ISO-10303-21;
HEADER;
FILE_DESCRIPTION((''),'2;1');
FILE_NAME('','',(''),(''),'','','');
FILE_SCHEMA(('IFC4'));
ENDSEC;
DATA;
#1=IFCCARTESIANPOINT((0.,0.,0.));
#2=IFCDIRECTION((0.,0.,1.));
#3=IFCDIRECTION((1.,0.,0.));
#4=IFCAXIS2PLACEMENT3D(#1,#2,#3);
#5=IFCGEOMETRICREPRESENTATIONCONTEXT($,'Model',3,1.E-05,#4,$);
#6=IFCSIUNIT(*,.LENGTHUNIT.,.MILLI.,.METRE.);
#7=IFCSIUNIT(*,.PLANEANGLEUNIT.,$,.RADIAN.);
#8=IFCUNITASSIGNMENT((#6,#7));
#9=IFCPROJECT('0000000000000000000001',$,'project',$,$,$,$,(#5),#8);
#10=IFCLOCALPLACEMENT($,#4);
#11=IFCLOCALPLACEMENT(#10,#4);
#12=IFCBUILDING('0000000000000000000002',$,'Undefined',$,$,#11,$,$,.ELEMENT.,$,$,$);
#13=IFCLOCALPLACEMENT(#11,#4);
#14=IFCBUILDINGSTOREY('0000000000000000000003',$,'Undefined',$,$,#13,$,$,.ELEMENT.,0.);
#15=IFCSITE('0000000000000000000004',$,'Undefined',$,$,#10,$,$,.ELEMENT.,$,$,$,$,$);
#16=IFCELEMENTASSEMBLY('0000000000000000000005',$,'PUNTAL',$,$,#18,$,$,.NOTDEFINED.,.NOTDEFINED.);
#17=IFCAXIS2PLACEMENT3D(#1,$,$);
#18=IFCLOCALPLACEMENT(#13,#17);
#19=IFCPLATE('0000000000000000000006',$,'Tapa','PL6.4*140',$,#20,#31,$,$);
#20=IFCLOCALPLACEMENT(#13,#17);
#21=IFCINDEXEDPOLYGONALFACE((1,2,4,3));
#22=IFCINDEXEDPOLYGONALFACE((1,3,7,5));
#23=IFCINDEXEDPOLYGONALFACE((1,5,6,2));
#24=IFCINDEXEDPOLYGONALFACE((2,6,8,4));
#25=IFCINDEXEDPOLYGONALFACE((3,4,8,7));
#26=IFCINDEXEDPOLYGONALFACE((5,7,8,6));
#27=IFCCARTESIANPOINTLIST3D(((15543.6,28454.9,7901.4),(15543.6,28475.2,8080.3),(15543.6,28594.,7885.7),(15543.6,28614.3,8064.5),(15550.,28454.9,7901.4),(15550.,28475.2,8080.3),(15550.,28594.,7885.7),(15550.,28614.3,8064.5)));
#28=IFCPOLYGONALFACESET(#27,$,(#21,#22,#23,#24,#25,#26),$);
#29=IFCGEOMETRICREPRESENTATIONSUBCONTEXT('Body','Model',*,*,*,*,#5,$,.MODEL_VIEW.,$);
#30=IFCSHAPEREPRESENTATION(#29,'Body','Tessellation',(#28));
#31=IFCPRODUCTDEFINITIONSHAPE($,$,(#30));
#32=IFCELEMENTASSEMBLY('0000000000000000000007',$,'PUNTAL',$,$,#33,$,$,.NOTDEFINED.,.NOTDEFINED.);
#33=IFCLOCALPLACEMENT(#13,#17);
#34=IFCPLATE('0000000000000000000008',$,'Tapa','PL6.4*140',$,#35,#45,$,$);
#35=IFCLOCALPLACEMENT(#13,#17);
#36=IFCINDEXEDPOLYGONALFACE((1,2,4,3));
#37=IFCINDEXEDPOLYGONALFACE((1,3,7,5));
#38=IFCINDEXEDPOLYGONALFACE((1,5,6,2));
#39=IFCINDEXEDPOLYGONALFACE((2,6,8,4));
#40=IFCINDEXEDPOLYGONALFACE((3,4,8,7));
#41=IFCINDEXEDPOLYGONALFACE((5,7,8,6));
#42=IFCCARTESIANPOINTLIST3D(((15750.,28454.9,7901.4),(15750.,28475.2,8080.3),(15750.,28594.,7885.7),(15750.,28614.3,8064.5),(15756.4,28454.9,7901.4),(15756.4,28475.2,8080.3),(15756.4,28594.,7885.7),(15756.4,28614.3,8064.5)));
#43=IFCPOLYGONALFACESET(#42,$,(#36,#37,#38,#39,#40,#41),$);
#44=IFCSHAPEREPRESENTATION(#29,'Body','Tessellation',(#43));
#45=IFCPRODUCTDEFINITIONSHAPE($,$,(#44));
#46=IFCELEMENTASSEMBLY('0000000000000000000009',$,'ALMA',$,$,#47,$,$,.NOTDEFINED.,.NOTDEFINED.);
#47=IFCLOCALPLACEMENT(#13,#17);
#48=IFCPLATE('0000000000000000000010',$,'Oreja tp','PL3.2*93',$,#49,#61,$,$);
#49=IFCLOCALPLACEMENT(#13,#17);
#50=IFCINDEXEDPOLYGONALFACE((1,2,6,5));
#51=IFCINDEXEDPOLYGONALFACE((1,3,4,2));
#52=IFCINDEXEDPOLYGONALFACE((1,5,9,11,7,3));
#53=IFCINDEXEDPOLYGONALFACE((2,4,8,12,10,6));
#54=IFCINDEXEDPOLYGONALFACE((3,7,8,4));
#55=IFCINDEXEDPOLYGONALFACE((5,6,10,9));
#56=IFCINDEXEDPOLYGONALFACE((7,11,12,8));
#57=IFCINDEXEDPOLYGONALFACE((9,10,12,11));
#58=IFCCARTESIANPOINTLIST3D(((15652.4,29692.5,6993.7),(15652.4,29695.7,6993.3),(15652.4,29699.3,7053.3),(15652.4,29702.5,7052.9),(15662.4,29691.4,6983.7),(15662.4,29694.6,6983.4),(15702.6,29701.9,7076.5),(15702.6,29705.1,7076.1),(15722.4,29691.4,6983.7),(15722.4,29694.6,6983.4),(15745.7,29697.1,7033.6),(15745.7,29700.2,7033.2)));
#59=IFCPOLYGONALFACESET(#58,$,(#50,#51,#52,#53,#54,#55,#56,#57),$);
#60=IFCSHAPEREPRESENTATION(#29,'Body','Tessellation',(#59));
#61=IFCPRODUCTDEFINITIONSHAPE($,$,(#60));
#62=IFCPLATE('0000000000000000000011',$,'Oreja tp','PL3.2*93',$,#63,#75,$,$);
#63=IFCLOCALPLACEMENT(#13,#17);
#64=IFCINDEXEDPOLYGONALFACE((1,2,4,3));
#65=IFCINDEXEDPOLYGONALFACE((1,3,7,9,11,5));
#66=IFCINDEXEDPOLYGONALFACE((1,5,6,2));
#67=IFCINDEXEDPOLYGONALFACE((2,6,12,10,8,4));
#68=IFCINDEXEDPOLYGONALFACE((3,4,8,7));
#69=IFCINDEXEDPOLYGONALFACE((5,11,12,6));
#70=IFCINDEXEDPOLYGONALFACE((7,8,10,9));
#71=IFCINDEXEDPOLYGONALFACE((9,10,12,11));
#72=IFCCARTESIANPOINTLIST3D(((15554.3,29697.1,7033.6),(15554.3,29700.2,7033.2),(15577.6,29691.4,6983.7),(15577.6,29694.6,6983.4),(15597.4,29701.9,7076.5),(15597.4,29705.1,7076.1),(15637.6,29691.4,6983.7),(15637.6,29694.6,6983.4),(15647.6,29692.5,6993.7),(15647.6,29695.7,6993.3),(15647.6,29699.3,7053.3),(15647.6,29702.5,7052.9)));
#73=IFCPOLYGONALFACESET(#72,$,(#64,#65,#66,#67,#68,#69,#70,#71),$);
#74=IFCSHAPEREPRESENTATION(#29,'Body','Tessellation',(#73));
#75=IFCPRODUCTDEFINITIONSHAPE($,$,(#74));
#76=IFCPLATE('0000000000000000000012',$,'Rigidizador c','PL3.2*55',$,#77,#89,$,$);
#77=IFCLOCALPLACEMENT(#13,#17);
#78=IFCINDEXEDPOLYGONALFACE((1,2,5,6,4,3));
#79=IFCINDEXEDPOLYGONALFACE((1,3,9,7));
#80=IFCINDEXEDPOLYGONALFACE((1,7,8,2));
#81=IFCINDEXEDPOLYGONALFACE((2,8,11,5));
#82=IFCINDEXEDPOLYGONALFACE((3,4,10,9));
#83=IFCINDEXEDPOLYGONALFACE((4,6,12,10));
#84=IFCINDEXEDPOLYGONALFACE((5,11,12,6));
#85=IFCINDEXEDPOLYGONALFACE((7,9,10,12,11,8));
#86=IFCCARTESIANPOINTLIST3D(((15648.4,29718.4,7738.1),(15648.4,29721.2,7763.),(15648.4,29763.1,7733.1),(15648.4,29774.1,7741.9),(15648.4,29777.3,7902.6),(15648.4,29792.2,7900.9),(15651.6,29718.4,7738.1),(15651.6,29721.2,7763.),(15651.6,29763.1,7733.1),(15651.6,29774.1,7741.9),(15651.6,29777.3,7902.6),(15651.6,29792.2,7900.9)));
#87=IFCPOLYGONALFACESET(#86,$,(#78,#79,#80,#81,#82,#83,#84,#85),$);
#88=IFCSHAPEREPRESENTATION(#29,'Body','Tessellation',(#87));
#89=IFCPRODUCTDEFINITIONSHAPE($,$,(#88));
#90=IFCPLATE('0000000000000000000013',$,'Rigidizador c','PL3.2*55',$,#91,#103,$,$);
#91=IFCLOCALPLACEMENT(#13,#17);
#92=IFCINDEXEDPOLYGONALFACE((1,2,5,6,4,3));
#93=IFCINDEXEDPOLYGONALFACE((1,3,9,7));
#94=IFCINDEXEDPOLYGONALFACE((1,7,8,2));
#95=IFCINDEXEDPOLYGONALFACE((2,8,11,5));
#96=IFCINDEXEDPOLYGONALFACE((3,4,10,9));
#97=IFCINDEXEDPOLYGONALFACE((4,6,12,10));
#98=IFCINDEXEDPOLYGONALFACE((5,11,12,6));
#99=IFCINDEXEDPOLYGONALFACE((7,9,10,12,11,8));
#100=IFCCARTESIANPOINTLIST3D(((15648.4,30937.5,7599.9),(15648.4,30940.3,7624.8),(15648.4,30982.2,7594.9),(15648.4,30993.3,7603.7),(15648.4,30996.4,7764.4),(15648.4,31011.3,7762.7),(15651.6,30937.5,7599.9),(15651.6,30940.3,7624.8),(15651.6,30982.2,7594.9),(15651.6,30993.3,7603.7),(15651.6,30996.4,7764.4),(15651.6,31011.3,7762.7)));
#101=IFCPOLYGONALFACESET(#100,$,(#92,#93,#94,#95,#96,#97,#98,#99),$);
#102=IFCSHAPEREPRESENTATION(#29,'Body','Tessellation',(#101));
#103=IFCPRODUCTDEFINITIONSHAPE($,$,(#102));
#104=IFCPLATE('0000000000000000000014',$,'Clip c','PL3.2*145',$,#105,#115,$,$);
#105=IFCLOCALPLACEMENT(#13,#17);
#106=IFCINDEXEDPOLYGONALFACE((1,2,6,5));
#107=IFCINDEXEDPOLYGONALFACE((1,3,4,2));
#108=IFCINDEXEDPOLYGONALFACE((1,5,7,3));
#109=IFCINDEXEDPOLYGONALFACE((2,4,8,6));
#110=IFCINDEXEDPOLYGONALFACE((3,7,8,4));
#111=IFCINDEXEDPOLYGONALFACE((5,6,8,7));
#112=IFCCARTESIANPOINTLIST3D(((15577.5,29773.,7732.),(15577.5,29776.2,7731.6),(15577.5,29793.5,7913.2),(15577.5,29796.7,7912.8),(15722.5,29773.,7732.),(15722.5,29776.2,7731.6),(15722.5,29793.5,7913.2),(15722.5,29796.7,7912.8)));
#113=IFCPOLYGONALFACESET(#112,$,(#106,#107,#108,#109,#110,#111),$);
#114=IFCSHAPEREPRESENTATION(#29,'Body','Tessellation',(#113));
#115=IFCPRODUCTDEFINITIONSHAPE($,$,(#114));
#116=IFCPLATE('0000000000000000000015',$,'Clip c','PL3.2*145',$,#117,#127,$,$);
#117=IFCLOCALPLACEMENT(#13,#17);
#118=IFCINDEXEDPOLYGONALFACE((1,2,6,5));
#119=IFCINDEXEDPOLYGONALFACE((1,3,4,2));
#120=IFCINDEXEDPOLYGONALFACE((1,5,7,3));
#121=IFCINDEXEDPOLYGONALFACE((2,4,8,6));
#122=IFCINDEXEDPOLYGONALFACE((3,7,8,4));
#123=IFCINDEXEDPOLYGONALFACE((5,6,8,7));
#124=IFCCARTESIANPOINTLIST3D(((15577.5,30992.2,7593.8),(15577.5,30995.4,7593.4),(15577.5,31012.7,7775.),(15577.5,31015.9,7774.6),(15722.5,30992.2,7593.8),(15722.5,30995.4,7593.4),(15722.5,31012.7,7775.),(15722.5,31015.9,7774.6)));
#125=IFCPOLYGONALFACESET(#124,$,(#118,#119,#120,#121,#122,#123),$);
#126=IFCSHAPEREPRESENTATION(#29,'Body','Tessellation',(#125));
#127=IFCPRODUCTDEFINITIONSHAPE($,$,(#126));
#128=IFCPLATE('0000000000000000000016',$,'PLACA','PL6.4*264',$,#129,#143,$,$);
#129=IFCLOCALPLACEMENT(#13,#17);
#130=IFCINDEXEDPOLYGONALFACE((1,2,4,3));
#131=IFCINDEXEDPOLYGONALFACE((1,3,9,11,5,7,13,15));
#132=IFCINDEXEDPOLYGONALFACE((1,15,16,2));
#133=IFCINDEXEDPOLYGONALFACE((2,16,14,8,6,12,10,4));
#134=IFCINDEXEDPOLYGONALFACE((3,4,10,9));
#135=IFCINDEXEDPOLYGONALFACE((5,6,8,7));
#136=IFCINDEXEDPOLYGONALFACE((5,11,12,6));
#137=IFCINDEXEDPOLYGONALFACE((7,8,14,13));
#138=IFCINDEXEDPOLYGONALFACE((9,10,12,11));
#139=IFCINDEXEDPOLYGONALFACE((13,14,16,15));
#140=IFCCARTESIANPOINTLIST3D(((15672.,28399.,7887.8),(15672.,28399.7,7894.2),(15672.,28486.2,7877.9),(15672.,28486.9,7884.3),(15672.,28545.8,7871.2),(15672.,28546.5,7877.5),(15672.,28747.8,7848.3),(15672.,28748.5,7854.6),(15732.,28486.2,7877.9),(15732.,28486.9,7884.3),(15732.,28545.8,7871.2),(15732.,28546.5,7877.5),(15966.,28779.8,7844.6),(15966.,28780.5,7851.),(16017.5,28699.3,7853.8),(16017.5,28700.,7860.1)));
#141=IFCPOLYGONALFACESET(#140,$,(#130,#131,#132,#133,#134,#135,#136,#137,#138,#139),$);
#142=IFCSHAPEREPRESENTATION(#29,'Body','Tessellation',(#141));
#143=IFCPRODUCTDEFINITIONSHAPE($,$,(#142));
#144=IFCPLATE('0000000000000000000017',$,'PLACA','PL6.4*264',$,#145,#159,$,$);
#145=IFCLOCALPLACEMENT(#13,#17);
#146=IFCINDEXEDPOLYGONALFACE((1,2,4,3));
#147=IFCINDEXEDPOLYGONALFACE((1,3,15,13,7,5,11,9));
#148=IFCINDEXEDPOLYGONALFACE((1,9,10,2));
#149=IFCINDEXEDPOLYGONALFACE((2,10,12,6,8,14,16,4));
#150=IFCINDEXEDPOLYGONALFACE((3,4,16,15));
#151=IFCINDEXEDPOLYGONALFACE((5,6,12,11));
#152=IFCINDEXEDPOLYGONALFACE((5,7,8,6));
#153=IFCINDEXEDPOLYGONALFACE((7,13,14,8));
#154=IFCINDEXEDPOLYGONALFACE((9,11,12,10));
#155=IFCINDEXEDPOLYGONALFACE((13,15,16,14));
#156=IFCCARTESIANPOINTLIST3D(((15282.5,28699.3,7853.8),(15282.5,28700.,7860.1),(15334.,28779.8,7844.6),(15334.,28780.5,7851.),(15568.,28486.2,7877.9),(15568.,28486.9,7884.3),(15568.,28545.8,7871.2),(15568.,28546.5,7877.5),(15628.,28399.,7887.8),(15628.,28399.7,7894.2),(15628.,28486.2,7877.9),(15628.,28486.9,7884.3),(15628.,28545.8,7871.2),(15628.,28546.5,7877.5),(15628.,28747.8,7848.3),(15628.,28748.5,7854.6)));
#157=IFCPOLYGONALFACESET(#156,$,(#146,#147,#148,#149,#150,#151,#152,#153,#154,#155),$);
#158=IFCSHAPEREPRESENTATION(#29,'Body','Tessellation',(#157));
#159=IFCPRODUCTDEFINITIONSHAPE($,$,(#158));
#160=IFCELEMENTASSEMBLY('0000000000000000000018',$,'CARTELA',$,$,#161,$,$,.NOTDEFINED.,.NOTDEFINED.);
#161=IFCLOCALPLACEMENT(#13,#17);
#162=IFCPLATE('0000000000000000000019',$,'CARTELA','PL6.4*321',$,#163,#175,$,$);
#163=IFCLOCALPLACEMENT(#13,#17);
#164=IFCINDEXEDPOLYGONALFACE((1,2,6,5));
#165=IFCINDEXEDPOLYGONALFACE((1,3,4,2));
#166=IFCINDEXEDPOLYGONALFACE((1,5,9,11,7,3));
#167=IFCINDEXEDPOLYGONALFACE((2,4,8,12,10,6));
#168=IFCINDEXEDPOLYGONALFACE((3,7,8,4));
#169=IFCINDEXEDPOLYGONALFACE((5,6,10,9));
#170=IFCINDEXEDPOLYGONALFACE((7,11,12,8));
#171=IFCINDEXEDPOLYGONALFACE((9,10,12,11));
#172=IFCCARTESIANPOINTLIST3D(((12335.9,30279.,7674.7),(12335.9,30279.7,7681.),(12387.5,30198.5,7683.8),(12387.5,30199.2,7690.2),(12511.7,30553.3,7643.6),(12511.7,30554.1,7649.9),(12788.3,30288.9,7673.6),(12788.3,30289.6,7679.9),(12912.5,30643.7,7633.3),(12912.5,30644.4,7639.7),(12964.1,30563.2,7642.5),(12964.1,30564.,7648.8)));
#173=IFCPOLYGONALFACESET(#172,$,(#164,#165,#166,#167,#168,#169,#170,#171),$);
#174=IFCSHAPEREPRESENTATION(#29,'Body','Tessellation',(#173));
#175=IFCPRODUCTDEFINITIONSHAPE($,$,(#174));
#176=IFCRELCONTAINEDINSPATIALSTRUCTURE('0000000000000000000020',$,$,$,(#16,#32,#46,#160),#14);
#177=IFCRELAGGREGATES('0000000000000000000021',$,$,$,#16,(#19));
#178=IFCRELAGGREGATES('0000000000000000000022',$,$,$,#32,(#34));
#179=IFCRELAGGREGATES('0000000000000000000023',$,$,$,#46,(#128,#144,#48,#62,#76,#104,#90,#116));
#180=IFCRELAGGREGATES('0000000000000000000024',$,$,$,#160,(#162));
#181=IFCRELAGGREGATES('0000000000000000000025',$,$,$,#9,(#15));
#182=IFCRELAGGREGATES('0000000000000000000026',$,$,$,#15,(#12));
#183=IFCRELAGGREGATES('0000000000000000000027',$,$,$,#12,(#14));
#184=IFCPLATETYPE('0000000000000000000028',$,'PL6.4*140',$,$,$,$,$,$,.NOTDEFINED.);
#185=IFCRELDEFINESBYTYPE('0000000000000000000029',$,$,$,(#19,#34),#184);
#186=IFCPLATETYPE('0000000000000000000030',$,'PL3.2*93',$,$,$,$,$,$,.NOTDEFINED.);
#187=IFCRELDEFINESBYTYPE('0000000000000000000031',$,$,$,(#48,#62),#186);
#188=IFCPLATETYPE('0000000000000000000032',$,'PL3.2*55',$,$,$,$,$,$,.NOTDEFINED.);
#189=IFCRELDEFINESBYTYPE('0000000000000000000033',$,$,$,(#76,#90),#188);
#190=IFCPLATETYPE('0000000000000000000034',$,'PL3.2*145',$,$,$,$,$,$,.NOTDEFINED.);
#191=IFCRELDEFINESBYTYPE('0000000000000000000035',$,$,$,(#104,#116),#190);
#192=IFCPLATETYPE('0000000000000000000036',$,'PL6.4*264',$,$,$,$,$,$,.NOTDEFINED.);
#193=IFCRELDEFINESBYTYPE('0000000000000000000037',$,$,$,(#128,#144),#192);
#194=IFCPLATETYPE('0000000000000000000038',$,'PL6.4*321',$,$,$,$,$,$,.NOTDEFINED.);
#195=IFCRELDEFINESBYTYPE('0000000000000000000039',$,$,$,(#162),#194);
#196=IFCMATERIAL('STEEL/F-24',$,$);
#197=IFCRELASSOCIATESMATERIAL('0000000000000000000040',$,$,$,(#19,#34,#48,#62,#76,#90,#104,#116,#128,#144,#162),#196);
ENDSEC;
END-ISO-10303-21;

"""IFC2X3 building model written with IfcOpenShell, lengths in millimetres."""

from ifc_helpers import new_model, si_unit, frame, origin_with_axes, place, context, subcontext, project, spatial, polyline, outline, extrude, boolean, material, type_object, element, aggregate, save


model = new_model("IFC2X3")

# Units and contexts
model_context = context("Model", 3, precision=1e-05, world=origin_with_axes())
body_context = subcontext(model_context, "Body", "Model", "MODEL_VIEW")
ifc_project = project(units=[si_unit("LENGTHUNIT", "METRE", prefix="MILLI"), si_unit("PLANEANGLEUNIT", "RADIAN")], contexts=[model_context])

# Site, building, storey
site_placement = place(None, origin_with_axes())
site = spatial("IfcSite", under=ifc_project, at=site_placement, Name="Undefined", CompositionType="ELEMENT")
building_placement = place(site_placement, origin_with_axes())
building = spatial("IfcBuilding", under=site, at=building_placement, Name="Undefined", CompositionType="ELEMENT")
storey_placement = place(building_placement, origin_with_axes())
storey = spatial("IfcBuildingStorey", under=building, at=storey_placement, Name="Undefined", CompositionType="ELEMENT", Elevation=0.0)

# Element assemblies, plates
assembly_1_placement = place(storey_placement, origin_with_axes())
assembly_1 = element("IfcElementAssembly", 1, at=assembly_1_placement, inside=storey, Name="PUNTAL", AssemblyPlace="NOTDEFINED", PredefinedType="NOTDEFINED")
ifc_material_1 = material(Name="STEEL/F-24")
plate_type_1 = type_object("IfcPlateType", Name="PL6.4*140", PredefinedType="NOTDEFINED")
plate_1_placement = place(assembly_1_placement, frame((15546.8, 28614.3, 8064.5), z_axis=(1.0, 0.0, 0.0), x_axis=(0.0, -0.993635, 0.112644)))
plate_1 = element("IfcPlate", 2, at=plate_1_placement, type_object=plate_type_1, material=ifc_material_1, Name="Tapa", Description="PL6.4*140", context=body_context, shape_type="SweptSolid", body=[
    extrude(outline(polyline([(0.0, 0.0), (140.0, 0.0), (140.0, 180.0), (0.0, 180.0), (0.0, 0.0)])), frame((0.0, 0.0, -3.2), z_axis=(0.0, 0.0, 1.0), x_axis=(1.0, 0.0, 0.0)), (0.0, 0.0, 1.0), 6.4),
])
aggregate(assembly_1, [plate_1])
assembly_2_placement = place(storey_placement, origin_with_axes())
assembly_2 = element("IfcElementAssembly", 3, at=assembly_2_placement, inside=storey, Name="PUNTAL", AssemblyPlace="NOTDEFINED", PredefinedType="NOTDEFINED")
plate_2_placement = place(assembly_2_placement, frame((15753.2, 28614.3, 8064.5), z_axis=(1.0, 0.0, 0.0), x_axis=(0.0, -0.993635, 0.112644)))
plate_2 = element("IfcPlate", 4, at=plate_2_placement, type_object=plate_type_1, material=ifc_material_1, Name="Tapa", Description="PL6.4*140", context=body_context, shape_type="SweptSolid", body=[
    extrude(outline(polyline([(0.0, 0.0), (140.0, 0.0), (140.0, 180.0), (0.0, 180.0), (0.0, 0.0)])), frame((0.0, 0.0, -3.2), z_axis=(0.0, 0.0, 1.0), x_axis=(1.0, 0.0, 0.0)), (0.0, 0.0, 1.0), 6.4),
])
aggregate(assembly_2, [plate_2])

# Element assembly, plates
assembly_3_placement = place(storey_placement, origin_with_axes())
assembly_3 = element("IfcElementAssembly", 5, at=assembly_3_placement, inside=storey, Name="ALMA", AssemblyPlace="NOTDEFINED", PredefinedType="NOTDEFINED")
plate_type_2 = type_object("IfcPlateType", Name="PL3.2*93", PredefinedType="NOTDEFINED")
plate_3_placement = place(assembly_3_placement, frame((15722.4, 29693.0, 6983.6), z_axis=(0.0, 0.993635, -0.112644), x_axis=(-1.0, -0.000004, -0.000037)))
plate_3 = element("IfcPlate", 6, at=plate_3_placement, type_object=plate_type_2, material=ifc_material_1, Name="Oreja tp", Description="PL3.2*93", context=body_context, shape_type="SweptSolid", body=[
    extrude(outline(polyline([(0.0, 0.0), (60.0, 0.0), (70.0, 10.0), (70.0, 70.0), (19.8, 93.3), (-23.3, 50.2), (0.0, 0.0)])), frame((0.0, 0.0, -1.6), z_axis=(0.0, 0.0, 1.0), x_axis=(1.0, 0.0, 0.0)), (0.0, 0.0, 1.0), 3.2),
])
plate_4_placement = place(assembly_3_placement, frame((15577.6, 29693.0, 6983.6), z_axis=(0.0, -0.993635, 0.112644), x_axis=(1.0, -0.000004, -0.000037)))
plate_4 = element("IfcPlate", 7, at=plate_4_placement, type_object=plate_type_2, material=ifc_material_1, Name="Oreja tp", Description="PL3.2*93", context=body_context, shape_type="SweptSolid", body=[
    extrude(outline(polyline([(0.0, 0.0), (60.0, 0.0), (70.0, 10.0), (70.0, 70.0), (19.8, 93.3), (-23.3, 50.2), (0.0, 0.0)])), frame((0.0, 0.0, -1.6), z_axis=(0.0, 0.0, 1.0), x_axis=(1.0, 0.0, 0.0)), (0.0, 0.0, 1.0), 3.2),
])
plate_type_3 = type_object("IfcPlateType", Name="PL3.2*55", PredefinedType="NOTDEFINED")
plate_5_placement = place(assembly_3_placement, frame((15650.0, 29792.2, 7900.9), z_axis=(1.0, 0.0, 0.0), x_axis=(0.0, -0.993635, 0.112644)))
plate_5 = element("IfcPlate", 8, at=plate_5_placement, type_object=plate_type_3, material=ifc_material_1, Name="Rigidizador c", Description="PL3.2*55", context=body_context, shape_type="SweptSolid", body=[
    extrude(outline(polyline([(0.0, 0.0), (15.0, 0.0), (55.0, 145.0), (55.0, 170.1), (10.0, 170.0), (0.0, 160.0), (0.0, 0.0)])), frame((0.0, 0.0, -1.6), z_axis=(0.0, 0.0, 1.0), x_axis=(1.0, 0.0, 0.0)), (0.0, 0.0, 1.0), 3.2),
])
plate_6_placement = place(assembly_3_placement, frame((15650.0, 31011.3, 7762.7), z_axis=(1.0, 0.0, 0.0), x_axis=(0.0, -0.993635, 0.112644)))
plate_6 = element("IfcPlate", 9, at=plate_6_placement, type_object=plate_type_3, material=ifc_material_1, Name="Rigidizador c", Description="PL3.2*55", context=body_context, shape_type="SweptSolid", body=[
    extrude(outline(polyline([(0.0, 0.0), (15.0, 0.0), (55.0, 145.0), (55.0, 170.1), (10.0, 170.0), (0.0, 160.0), (0.0, 0.0)])), frame((0.0, 0.0, -1.6), z_axis=(0.0, 0.0, 1.0), x_axis=(1.0, 0.0, 0.0)), (0.0, 0.0, 1.0), 3.2),
])
plate_type_4 = type_object("IfcPlateType", Name="PL3.2*145", PredefinedType="NOTDEFINED")
plate_7_placement = place(assembly_3_placement, frame((15722.5, 29774.6, 7731.8), z_axis=(0.0, -0.993645, 0.112559), x_axis=(0.0, 0.112559, 0.993645)))
plate_7 = element("IfcPlate", 10, at=plate_7_placement, type_object=plate_type_4, material=ifc_material_1, Name="Clip c", Description="PL3.2*145", context=body_context, shape_type="SweptSolid", body=[
    extrude(outline(polyline([(0.0, 0.0), (182.3, 0.0), (182.3, 145.0), (0.0, 145.0), (0.0, 0.0)])), frame((0.0, 0.0, -1.6), z_axis=(0.0, 0.0, 1.0), x_axis=(1.0, 0.0, 0.0)), (0.0, 0.0, 1.0), 3.2),
])
plate_8_placement = place(assembly_3_placement, frame((15722.5, 30993.8, 7593.6), z_axis=(0.0, -0.993645, 0.112559), x_axis=(0.0, 0.112559, 0.993645)))
plate_8 = element("IfcPlate", 11, at=plate_8_placement, type_object=plate_type_4, material=ifc_material_1, Name="Clip c", Description="PL3.2*145", context=body_context, shape_type="SweptSolid", body=[
    extrude(outline(polyline([(0.0, 0.0), (182.3, 0.0), (182.3, 145.0), (0.0, 145.0), (0.0, 0.0)])), frame((0.0, 0.0, -1.6), z_axis=(0.0, 0.0, 1.0), x_axis=(1.0, 0.0, 0.0)), (0.0, 0.0, 1.0), 3.2),
])
plate_type_5 = type_object("IfcPlateType", Name="PL6.4*264", PredefinedType="NOTDEFINED")
plate_9_placement = place(assembly_3_placement, frame((15672.0, 28748.1, 7851.4), z_axis=(-0.000011, 0.112712, 0.993628), x_axis=(0.0, -0.993628, 0.112712)))
plate_9 = element("IfcPlate", 12, at=plate_9_placement, type_object=plate_type_5, material=ifc_material_1, Name="PLACA", Description="PL6.4*264", context=body_context, shape_type="CSG", body=[
    boolean("DIFFERENCE", extrude(outline(polyline([(0.0, 0.0), (351.0, 0.0), (48.8, 345.5), (-32.2, 294.0), (0.0, 0.0)])), frame((0.0, 0.0, -3.2), z_axis=(0.0, 0.0, 1.0), x_axis=(1.0, 0.0, 0.0)), (0.0, 0.0, 1.0), 6.4), extrude(outline(polyline([(0.0, 0.0), (60.0, 0.0), (60.0, 60.0), (0.0, 60.0), (0.0, 0.0)])), frame((203.3, 0.0, 5.0), z_axis=(-0.000317, -0.000011, -1.0), x_axis=(0.0, 1.0, -0.000011)), (0.0, 0.0, 1.0), 12.0)),
])
plate_10_placement = place(assembly_3_placement, frame((15628.0, 28748.1, 7851.4), z_axis=(-0.000011, -0.112712, -0.993628), x_axis=(0.0, -0.993628, 0.112712)))
plate_10 = element("IfcPlate", 13, at=plate_10_placement, type_object=plate_type_5, material=ifc_material_1, Name="PLACA", Description="PL6.4*264", context=body_context, shape_type="CSG", body=[
    boolean("DIFFERENCE", extrude(outline(polyline([(0.0, 0.0), (351.0, 0.0), (48.8, 345.5), (-32.2, 294.0), (0.0, 0.0)])), frame((0.0, 0.0, -3.2), z_axis=(0.0, 0.0, 1.0), x_axis=(1.0, 0.0, 0.0)), (0.0, 0.0, 1.0), 6.4), extrude(outline(polyline([(0.0, 0.0), (60.0, 0.0), (60.0, 60.0), (0.0, 60.0), (0.0, 0.0)])), frame((203.3, 0.0, 7.0), z_axis=(0.000317, 0.000011, -1.0), x_axis=(0.0, 1.0, 0.000011)), (0.0, 0.0, 1.0), 12.0)),
])

# Element assembly, plate
assembly_4_placement = place(storey_placement, origin_with_axes())
assembly_4 = element("IfcElementAssembly", 14, at=assembly_4_placement, inside=storey, Name="CARTELA", AssemblyPlace="NOTDEFINED", PredefinedType="NOTDEFINED")
plate_type_6 = type_object("IfcPlateType", Name="PL6.4*321", PredefinedType="NOTDEFINED")
plate_11_placement = place(assembly_4_placement, frame((12511.7, 30553.7, 7646.8), z_axis=(0.0, -0.11264, -0.993636), x_axis=(0.975208, 0.219884, -0.024926)))
plate_11 = element("IfcPlate", 15, at=plate_11_placement, type_object=plate_type_6, material=ifc_material_1, Name="CARTELA", Description="PL6.4*321", context=body_context, shape_type="SweptSolid", body=[
    extrude(outline(polyline([(0.0, 0.0), (411.0, 0.0), (443.3, 90.4), (210.8, 320.8), (-200.2, 320.8), (-232.5, 230.4), (0.0, 0.0)])), frame((0.0, 0.0, -3.2), z_axis=(0.0, 0.0, 1.0), x_axis=(1.0, 0.0, 0.0)), (0.0, 0.0, 1.0), 6.4),
])

aggregate(assembly_3, [plate_9, plate_10, plate_3, plate_4, plate_5, plate_7, plate_6, plate_8])

aggregate(assembly_4, [plate_11])

save(model, "model.ifc")
